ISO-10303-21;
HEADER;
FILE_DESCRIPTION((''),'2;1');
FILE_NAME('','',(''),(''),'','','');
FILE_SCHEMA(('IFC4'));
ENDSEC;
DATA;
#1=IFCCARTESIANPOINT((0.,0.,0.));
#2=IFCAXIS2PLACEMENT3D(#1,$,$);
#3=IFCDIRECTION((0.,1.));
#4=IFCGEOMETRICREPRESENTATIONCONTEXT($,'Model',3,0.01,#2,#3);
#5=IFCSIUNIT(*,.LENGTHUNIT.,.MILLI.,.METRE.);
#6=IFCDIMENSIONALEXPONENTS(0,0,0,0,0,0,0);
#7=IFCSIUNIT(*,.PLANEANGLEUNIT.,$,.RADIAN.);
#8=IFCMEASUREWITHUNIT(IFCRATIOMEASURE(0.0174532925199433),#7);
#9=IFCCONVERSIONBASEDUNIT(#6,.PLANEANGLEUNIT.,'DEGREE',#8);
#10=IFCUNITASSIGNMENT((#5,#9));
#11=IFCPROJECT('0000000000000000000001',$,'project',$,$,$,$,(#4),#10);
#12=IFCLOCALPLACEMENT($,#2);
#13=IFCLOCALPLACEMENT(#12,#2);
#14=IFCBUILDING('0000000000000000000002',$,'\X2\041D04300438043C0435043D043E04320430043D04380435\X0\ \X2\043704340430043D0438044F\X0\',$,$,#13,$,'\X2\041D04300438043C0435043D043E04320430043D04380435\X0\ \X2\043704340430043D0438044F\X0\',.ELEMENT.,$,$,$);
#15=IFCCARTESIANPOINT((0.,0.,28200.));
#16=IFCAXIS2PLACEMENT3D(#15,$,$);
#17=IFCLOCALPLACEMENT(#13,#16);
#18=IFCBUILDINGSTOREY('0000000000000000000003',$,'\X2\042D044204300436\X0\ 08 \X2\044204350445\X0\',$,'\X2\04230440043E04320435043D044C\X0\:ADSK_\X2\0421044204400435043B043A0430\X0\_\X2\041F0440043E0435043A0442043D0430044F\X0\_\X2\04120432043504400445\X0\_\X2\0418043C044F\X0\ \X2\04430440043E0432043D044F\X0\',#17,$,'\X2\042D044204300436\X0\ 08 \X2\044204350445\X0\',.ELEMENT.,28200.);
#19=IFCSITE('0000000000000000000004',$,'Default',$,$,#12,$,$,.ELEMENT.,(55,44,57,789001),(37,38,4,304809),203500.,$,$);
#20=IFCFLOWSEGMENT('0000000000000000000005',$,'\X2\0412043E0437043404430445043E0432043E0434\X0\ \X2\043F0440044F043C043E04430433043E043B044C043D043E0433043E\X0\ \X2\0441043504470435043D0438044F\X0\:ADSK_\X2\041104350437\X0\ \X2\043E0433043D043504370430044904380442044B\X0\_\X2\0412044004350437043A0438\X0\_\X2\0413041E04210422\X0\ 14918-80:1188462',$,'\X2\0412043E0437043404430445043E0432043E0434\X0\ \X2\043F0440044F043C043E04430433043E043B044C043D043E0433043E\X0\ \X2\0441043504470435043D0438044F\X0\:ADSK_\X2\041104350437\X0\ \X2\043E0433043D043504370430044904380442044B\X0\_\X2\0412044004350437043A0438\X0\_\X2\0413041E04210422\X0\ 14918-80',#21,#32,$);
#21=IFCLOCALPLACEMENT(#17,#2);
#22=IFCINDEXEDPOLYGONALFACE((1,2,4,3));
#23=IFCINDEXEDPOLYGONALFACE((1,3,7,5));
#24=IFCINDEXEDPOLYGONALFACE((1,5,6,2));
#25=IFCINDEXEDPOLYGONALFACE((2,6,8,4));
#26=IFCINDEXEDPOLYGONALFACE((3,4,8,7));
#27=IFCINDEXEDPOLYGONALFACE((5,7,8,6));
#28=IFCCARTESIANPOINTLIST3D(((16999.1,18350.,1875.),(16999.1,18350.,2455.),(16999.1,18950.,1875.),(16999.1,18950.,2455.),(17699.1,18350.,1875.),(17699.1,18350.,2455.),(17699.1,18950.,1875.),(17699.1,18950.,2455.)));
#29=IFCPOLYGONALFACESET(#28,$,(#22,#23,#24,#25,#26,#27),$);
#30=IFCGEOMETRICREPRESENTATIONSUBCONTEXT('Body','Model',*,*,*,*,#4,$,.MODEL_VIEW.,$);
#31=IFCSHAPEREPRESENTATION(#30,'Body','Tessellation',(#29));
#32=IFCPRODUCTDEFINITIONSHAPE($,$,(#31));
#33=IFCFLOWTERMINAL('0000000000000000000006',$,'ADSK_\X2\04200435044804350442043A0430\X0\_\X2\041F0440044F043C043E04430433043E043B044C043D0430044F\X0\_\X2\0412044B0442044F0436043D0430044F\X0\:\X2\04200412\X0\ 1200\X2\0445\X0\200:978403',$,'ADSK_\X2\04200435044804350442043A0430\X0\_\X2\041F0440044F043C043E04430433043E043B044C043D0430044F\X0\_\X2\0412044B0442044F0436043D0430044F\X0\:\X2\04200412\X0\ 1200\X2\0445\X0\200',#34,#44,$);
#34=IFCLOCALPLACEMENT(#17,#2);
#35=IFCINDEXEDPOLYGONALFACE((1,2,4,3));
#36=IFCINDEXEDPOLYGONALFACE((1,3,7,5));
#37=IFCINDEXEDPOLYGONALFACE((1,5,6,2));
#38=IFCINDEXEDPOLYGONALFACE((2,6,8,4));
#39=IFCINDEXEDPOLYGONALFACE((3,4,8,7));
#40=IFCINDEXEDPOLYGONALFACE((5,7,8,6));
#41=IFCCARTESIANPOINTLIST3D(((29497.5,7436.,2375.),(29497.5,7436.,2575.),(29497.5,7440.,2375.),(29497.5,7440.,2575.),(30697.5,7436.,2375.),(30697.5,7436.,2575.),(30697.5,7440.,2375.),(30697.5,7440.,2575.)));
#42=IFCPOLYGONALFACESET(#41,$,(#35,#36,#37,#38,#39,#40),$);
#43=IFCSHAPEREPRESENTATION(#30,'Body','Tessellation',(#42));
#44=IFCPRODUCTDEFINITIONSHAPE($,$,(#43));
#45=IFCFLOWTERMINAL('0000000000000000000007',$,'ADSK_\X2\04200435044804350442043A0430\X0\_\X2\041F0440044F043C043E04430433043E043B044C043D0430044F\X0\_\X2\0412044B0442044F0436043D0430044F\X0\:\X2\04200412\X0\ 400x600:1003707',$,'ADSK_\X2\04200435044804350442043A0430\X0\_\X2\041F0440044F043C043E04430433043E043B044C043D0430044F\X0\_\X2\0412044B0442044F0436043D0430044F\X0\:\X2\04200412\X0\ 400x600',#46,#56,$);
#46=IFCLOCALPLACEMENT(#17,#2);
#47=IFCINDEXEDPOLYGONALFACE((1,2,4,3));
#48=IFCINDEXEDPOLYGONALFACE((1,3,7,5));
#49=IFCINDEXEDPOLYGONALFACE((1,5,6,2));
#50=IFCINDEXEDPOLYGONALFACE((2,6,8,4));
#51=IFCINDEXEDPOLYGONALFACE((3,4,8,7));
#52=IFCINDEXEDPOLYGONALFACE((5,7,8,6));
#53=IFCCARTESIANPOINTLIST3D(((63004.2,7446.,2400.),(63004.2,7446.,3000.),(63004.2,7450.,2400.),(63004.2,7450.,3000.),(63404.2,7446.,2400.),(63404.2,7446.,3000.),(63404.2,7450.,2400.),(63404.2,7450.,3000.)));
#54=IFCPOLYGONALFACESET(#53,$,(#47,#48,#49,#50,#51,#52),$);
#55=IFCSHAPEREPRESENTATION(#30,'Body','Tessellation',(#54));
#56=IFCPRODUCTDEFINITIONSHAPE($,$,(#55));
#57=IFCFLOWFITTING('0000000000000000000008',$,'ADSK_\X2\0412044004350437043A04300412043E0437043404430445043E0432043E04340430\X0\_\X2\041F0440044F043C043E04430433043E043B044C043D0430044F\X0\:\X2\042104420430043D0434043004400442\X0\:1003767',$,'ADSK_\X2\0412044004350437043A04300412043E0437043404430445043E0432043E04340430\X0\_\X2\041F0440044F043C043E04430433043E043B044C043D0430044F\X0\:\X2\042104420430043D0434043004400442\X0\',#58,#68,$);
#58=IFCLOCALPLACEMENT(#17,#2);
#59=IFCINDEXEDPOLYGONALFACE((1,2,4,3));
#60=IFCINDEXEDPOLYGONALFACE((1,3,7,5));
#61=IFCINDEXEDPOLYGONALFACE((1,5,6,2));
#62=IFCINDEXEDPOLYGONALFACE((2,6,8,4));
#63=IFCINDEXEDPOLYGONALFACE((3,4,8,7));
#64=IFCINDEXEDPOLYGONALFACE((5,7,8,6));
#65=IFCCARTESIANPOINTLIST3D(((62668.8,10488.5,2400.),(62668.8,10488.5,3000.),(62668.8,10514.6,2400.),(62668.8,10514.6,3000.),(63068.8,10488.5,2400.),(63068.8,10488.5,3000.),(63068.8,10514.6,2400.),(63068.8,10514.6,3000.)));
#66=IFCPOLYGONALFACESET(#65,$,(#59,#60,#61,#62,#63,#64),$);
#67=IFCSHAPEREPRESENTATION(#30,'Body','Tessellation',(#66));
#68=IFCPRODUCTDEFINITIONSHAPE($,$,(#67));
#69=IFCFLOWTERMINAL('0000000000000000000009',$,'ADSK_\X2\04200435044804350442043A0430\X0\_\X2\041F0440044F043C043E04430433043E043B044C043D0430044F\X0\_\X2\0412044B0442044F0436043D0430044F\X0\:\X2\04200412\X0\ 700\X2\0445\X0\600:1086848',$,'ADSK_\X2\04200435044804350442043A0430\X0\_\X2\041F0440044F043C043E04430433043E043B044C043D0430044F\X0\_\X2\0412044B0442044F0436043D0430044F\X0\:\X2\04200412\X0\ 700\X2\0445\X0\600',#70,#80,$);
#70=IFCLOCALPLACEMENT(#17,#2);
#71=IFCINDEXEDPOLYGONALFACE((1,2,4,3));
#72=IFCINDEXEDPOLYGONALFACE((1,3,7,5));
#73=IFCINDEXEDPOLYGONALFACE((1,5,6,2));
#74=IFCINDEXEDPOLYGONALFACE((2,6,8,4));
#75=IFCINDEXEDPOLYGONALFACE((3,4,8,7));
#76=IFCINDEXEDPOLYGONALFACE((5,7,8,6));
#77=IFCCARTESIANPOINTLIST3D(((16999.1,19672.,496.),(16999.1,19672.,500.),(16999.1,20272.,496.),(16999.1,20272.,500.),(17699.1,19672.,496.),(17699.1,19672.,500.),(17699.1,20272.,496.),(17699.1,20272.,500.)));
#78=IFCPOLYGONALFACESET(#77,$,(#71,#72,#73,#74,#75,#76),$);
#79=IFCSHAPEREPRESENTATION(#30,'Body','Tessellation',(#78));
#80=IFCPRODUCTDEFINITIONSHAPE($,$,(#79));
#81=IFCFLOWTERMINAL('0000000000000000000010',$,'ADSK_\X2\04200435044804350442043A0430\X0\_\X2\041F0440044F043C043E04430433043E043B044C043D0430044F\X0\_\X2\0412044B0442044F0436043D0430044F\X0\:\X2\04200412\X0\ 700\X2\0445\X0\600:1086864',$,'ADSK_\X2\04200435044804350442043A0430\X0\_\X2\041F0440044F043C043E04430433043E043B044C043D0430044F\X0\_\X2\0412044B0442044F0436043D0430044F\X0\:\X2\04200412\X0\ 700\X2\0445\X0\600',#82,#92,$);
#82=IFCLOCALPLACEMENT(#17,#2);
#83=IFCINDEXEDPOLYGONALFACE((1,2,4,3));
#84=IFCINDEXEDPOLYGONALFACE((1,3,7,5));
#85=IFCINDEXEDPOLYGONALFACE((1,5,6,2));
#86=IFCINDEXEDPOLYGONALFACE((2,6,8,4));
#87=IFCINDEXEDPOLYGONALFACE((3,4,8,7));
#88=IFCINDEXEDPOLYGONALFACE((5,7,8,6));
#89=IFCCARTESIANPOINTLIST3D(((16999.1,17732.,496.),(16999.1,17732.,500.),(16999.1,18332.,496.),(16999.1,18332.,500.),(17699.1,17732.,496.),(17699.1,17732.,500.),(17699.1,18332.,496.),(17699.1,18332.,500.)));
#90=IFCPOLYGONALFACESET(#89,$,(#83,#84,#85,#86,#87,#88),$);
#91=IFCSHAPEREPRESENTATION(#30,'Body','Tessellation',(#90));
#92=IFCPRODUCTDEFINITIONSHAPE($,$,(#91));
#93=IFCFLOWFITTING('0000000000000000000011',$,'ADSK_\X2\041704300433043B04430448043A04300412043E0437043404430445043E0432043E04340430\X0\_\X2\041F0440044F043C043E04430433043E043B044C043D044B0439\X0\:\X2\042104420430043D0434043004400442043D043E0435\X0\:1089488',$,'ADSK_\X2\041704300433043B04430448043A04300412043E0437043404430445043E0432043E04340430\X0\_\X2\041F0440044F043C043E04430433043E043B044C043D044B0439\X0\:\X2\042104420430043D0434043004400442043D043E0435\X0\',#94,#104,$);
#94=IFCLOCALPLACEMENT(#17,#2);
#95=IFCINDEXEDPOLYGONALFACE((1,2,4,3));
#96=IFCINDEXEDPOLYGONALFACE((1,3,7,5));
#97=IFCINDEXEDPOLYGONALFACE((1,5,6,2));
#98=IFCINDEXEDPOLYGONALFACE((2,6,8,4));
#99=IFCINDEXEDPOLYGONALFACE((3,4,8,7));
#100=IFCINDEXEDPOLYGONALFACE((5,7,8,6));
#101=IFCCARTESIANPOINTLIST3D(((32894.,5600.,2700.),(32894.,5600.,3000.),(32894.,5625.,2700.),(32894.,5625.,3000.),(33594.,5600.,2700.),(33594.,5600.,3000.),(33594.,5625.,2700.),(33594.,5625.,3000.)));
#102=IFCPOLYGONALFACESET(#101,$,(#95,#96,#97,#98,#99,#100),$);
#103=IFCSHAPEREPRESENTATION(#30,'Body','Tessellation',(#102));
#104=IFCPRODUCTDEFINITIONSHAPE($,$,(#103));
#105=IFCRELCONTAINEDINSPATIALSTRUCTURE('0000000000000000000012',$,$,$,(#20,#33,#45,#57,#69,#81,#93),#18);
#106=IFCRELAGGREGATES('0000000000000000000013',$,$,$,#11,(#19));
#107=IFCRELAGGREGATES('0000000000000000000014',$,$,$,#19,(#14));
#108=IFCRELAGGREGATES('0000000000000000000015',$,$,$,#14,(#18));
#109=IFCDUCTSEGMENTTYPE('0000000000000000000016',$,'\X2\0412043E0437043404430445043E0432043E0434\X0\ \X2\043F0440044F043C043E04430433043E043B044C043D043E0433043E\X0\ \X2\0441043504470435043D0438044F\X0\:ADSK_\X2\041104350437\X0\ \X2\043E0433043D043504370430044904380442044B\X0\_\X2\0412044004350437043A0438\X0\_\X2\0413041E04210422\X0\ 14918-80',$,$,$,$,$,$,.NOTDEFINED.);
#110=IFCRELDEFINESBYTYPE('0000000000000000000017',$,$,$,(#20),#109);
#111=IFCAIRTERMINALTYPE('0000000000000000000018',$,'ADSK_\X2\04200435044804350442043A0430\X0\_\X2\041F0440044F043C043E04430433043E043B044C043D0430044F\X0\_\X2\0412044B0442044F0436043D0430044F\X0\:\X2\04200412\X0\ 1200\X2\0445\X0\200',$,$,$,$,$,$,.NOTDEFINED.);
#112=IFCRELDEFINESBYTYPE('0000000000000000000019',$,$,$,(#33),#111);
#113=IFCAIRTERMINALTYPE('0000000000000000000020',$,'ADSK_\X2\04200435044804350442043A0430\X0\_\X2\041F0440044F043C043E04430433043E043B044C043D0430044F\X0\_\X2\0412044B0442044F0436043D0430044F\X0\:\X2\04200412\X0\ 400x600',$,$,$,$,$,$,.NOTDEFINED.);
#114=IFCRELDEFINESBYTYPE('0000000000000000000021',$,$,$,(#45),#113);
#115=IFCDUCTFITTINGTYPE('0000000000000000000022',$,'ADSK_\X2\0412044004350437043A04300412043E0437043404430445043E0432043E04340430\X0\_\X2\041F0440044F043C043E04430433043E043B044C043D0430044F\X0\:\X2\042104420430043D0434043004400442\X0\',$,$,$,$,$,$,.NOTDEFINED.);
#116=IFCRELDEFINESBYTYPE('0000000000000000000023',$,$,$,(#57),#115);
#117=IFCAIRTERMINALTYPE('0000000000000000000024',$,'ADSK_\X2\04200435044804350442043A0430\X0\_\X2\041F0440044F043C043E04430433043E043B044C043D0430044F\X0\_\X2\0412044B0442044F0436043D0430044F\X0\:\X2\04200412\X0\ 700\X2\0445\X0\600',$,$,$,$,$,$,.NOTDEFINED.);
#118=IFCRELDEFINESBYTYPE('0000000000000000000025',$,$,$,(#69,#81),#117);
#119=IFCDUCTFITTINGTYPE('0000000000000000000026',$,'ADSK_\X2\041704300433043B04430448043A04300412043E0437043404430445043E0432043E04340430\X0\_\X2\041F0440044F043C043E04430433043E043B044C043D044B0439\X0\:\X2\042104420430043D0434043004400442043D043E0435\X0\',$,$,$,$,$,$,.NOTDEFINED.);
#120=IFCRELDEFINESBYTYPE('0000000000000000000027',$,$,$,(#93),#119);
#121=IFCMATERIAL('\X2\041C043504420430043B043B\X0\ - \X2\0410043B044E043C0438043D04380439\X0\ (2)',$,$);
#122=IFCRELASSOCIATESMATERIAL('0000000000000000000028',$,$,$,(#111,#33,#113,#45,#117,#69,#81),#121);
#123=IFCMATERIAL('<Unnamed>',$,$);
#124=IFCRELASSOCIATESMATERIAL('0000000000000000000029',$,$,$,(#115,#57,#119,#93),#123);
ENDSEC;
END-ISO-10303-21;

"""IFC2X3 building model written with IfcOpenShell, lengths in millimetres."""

from ifc_helpers import new_model, entity, si_unit, converted_unit, direction, frame, origin, origin_2d_with_axis, place, context, subcontext, project, spatial, rectangle, extrude, source, transform, mapped, material, type_object, type_shapes, element, save


model = new_model("IFC2X3")

# Units and contexts
model_context = context("Model", 3, precision=0.01, world=origin(), true_north=direction((0.0, 1.0)))
body_context = subcontext(model_context, "Body", "Model", "MODEL_VIEW")
ifc_project = project(units=[si_unit("LENGTHUNIT", "METRE", prefix="MILLI"), converted_unit("PLANEANGLEUNIT", "DEGREE", entity("IfcRatioMeasure", 0.0174532925199433), si_unit("PLANEANGLEUNIT", "RADIAN"), dimensions=[0, 0, 0, 0, 0, 0, 0])], contexts=[model_context])

# Site, building, storey
site_placement = place(None, origin())
site = spatial("IfcSite", under=ifc_project, at=site_placement, Name="Default", CompositionType="ELEMENT", RefLatitude=(55, 44, 57, 789001), RefLongitude=(37, 38, 4, 304809), RefElevation=203500.0)
building_placement = place(site_placement, origin())
building = spatial("IfcBuilding", under=site, at=building_placement, Name="Наименование здания", LongName="Наименование здания", CompositionType="ELEMENT")
storey_placement = place(building_placement, frame((0.0, 0.0, 28200.0)))
storey = spatial("IfcBuildingStorey", under=building, at=storey_placement, Name="Этаж 08 тех", ObjectType="Уровень:ADSK_Стрелка_Проектная_Вверх_Имя уровня", LongName="Этаж 08 тех", CompositionType="ELEMENT", Elevation=28200.0)

# Flow segment
duct_segment_type_1 = type_object("IfcDuctSegmentType", Name="Воздуховод прямоугольного сечения:ADSK_Без огнезащиты_Врезки_ГОСТ 14918-80", PredefinedType="NOTDEFINED")
flow_segment_1_placement = place(storey_placement, frame((16999.1, 18350.0, 1875.0)))
element("IfcFlowSegment", 1, at=flow_segment_1_placement, inside=storey, type_object=duct_segment_type_1, Name="Воздуховод прямоугольного сечения:ADSK_Без огнезащиты_Врезки_ГОСТ 14918-80:1188462", ObjectType="Воздуховод прямоугольного сечения:ADSK_Без огнезащиты_Врезки_ГОСТ 14918-80", context=body_context, shape_type="SweptSolid", body=[
    extrude(rectangle(XDim=700.0, YDim=600.0, at=origin_2d_with_axis()), frame((350.0, 300.0, 0.0)), (0.0, 0.0, 1.0), 580.0),
])

# Flow terminals
ifc_material_1 = material(Name="Металл - Алюминий (2)")
air_terminal_type_1 = type_object("IfcAirTerminalType", Name="ADSK_Решетка_Прямоугольная_Вытяжная:РВ 1200х200", PredefinedType="NOTDEFINED", material=ifc_material_1)
shared_shape_1 = source(origin(), body_context, "Body", "SweptSolid", [
    extrude(rectangle(XDim=4.0, YDim=1200.0, at=origin_2d_with_axis()), frame((0.0, -2.0, -100.0), z_axis=(0.0, 0.0, 1.0), x_axis=(0.0, 1.0, 0.0)), (0.0, 0.0, 1.0), 200.0),
])
type_shapes(air_terminal_type_1, [shared_shape_1])
flow_terminal_1_placement = place(storey_placement, frame((30097.5, 7440.0, 2475.0)))
element("IfcFlowTerminal", 2, at=flow_terminal_1_placement, inside=storey, type_object=air_terminal_type_1, material=ifc_material_1, Name="ADSK_Решетка_Прямоугольная_Вытяжная:РВ 1200х200:978403", ObjectType="ADSK_Решетка_Прямоугольная_Вытяжная:РВ 1200х200", context=body_context, shape_type="MappedRepresentation", body=[
    mapped(shared_shape_1, transform((0.0, 0.0, 0.0), scale=1.0)),
])
air_terminal_type_2 = type_object("IfcAirTerminalType", Name="ADSK_Решетка_Прямоугольная_Вытяжная:РВ 400x600", PredefinedType="NOTDEFINED", material=ifc_material_1)
shared_shape_2 = source(origin(), body_context, "Body", "SweptSolid", [
    extrude(rectangle(XDim=4.0, YDim=400.0, at=origin_2d_with_axis()), frame((0.0, -2.0, -300.0), z_axis=(0.0, 0.0, 1.0), x_axis=(0.0, 1.0, 0.0)), (0.0, 0.0, 1.0), 600.0),
])
type_shapes(air_terminal_type_2, [shared_shape_2])
flow_terminal_2_placement = place(storey_placement, frame((63204.2, 7450.0, 2700.0)))
element("IfcFlowTerminal", 3, at=flow_terminal_2_placement, inside=storey, type_object=air_terminal_type_2, material=ifc_material_1, Name="ADSK_Решетка_Прямоугольная_Вытяжная:РВ 400x600:1003707", ObjectType="ADSK_Решетка_Прямоугольная_Вытяжная:РВ 400x600", context=body_context, shape_type="MappedRepresentation", body=[
    mapped(shared_shape_2, transform((0.0, 0.0, 0.0), scale=1.0)),
])

# Flow fitting
ifc_material_2 = material(Name="<Unnamed>")
duct_fitting_type_1 = type_object("IfcDuctFittingType", Name="ADSK_ВрезкаВоздуховода_Прямоугольная:Стандарт", PredefinedType="NOTDEFINED", material=ifc_material_2)
shared_shape_3 = source(origin(), body_context, "Body", "SweptSolid", [
    extrude(rectangle(XDim=600.0, YDim=26.1, at=origin_2d_with_axis()), frame((7.0, 0.0, -200.0), z_axis=(0.0, 0.0, 1.0), x_axis=(0.0, -1.0, 0.0)), (0.0, 0.0, 1.0), 400.0),
])
type_shapes(duct_fitting_type_1, [shared_shape_3])
flow_fitting_1_placement = place(storey_placement, frame((62868.8, 10508.5, 2700.0), z_axis=(-1.0, 0.0, 0.0), x_axis=(0.0, -1.0, 0.0)))
element("IfcFlowFitting", 4, at=flow_fitting_1_placement, inside=storey, type_object=duct_fitting_type_1, material=ifc_material_2, Name="ADSK_ВрезкаВоздуховода_Прямоугольная:Стандарт:1003767", ObjectType="ADSK_ВрезкаВоздуховода_Прямоугольная:Стандарт", context=body_context, shape_type="MappedRepresentation", body=[
    mapped(shared_shape_3, transform((0.0, 0.0, 0.0), scale=1.0)),
])

# Flow terminals
air_terminal_type_3 = type_object("IfcAirTerminalType", Name="ADSK_Решетка_Прямоугольная_Вытяжная:РВ 700х600", PredefinedType="NOTDEFINED", material=ifc_material_1)
shared_shape_4 = source(origin(), body_context, "Body", "SweptSolid", [
    extrude(rectangle(XDim=4.0, YDim=700.0, at=origin_2d_with_axis()), frame((0.0, -2.0, -300.0), z_axis=(0.0, 0.0, 1.0), x_axis=(0.0, 1.0, 0.0)), (0.0, 0.0, 1.0), 600.0),
])
type_shapes(air_terminal_type_3, [shared_shape_4])
for number, where, z_axis, x_axis, name in (
    (5, (17349.1, 19972.0, 500.0), (0.0, -1.0, 0.0), (1.0, 0.0, 0.0), "ADSK_Решетка_Прямоугольная_Вытяжная:РВ 700х600:1086848"),
    (6, (17349.1, 18032.0, 500.0), (0.0, -1.0, 0.0), (1.0, 0.0, 0.0), "ADSK_Решетка_Прямоугольная_Вытяжная:РВ 700х600:1086864"),
):
    element("IfcFlowTerminal", number, at=place(storey_placement, frame(where, z_axis=z_axis, x_axis=x_axis)), inside=storey, type_object=air_terminal_type_3, material=ifc_material_1, Name=name, ObjectType="ADSK_Решетка_Прямоугольная_Вытяжная:РВ 700х600", context=body_context, shape_type="MappedRepresentation", body=[
        mapped(shared_shape_4, transform((0.0, 0.0, 0.0), scale=1.0)),
    ])

# Flow fitting
duct_fitting_type_2 = type_object("IfcDuctFittingType", Name="ADSK_ЗаглушкаВоздуховода_Прямоугольный:Стандартное", PredefinedType="NOTDEFINED", material=ifc_material_2)
shared_shape_5 = source(origin(), body_context, "Body", "SweptSolid", [
    extrude(rectangle(XDim=25.0, YDim=700.0, at=origin_2d_with_axis()), frame((12.5, 0.0, -150.0)), (0.0, 0.0, 1.0), 300.0),
])
type_shapes(duct_fitting_type_2, [shared_shape_5])
flow_fitting_2_placement = place(storey_placement, frame((33244.0, 5625.0, 2850.0), z_axis=(0.0, 0.0, 1.0), x_axis=(0.0, -1.0, 0.0)))
element("IfcFlowFitting", 7, at=flow_fitting_2_placement, inside=storey, type_object=duct_fitting_type_2, material=ifc_material_2, Name="ADSK_ЗаглушкаВоздуховода_Прямоугольный:Стандартное:1089488", ObjectType="ADSK_ЗаглушкаВоздуховода_Прямоугольный:Стандартное", context=body_context, shape_type="MappedRepresentation", body=[
    mapped(shared_shape_5, transform((0.0, 0.0, 0.0), scale=1.0)),
])

save(model, "model.ifc")
